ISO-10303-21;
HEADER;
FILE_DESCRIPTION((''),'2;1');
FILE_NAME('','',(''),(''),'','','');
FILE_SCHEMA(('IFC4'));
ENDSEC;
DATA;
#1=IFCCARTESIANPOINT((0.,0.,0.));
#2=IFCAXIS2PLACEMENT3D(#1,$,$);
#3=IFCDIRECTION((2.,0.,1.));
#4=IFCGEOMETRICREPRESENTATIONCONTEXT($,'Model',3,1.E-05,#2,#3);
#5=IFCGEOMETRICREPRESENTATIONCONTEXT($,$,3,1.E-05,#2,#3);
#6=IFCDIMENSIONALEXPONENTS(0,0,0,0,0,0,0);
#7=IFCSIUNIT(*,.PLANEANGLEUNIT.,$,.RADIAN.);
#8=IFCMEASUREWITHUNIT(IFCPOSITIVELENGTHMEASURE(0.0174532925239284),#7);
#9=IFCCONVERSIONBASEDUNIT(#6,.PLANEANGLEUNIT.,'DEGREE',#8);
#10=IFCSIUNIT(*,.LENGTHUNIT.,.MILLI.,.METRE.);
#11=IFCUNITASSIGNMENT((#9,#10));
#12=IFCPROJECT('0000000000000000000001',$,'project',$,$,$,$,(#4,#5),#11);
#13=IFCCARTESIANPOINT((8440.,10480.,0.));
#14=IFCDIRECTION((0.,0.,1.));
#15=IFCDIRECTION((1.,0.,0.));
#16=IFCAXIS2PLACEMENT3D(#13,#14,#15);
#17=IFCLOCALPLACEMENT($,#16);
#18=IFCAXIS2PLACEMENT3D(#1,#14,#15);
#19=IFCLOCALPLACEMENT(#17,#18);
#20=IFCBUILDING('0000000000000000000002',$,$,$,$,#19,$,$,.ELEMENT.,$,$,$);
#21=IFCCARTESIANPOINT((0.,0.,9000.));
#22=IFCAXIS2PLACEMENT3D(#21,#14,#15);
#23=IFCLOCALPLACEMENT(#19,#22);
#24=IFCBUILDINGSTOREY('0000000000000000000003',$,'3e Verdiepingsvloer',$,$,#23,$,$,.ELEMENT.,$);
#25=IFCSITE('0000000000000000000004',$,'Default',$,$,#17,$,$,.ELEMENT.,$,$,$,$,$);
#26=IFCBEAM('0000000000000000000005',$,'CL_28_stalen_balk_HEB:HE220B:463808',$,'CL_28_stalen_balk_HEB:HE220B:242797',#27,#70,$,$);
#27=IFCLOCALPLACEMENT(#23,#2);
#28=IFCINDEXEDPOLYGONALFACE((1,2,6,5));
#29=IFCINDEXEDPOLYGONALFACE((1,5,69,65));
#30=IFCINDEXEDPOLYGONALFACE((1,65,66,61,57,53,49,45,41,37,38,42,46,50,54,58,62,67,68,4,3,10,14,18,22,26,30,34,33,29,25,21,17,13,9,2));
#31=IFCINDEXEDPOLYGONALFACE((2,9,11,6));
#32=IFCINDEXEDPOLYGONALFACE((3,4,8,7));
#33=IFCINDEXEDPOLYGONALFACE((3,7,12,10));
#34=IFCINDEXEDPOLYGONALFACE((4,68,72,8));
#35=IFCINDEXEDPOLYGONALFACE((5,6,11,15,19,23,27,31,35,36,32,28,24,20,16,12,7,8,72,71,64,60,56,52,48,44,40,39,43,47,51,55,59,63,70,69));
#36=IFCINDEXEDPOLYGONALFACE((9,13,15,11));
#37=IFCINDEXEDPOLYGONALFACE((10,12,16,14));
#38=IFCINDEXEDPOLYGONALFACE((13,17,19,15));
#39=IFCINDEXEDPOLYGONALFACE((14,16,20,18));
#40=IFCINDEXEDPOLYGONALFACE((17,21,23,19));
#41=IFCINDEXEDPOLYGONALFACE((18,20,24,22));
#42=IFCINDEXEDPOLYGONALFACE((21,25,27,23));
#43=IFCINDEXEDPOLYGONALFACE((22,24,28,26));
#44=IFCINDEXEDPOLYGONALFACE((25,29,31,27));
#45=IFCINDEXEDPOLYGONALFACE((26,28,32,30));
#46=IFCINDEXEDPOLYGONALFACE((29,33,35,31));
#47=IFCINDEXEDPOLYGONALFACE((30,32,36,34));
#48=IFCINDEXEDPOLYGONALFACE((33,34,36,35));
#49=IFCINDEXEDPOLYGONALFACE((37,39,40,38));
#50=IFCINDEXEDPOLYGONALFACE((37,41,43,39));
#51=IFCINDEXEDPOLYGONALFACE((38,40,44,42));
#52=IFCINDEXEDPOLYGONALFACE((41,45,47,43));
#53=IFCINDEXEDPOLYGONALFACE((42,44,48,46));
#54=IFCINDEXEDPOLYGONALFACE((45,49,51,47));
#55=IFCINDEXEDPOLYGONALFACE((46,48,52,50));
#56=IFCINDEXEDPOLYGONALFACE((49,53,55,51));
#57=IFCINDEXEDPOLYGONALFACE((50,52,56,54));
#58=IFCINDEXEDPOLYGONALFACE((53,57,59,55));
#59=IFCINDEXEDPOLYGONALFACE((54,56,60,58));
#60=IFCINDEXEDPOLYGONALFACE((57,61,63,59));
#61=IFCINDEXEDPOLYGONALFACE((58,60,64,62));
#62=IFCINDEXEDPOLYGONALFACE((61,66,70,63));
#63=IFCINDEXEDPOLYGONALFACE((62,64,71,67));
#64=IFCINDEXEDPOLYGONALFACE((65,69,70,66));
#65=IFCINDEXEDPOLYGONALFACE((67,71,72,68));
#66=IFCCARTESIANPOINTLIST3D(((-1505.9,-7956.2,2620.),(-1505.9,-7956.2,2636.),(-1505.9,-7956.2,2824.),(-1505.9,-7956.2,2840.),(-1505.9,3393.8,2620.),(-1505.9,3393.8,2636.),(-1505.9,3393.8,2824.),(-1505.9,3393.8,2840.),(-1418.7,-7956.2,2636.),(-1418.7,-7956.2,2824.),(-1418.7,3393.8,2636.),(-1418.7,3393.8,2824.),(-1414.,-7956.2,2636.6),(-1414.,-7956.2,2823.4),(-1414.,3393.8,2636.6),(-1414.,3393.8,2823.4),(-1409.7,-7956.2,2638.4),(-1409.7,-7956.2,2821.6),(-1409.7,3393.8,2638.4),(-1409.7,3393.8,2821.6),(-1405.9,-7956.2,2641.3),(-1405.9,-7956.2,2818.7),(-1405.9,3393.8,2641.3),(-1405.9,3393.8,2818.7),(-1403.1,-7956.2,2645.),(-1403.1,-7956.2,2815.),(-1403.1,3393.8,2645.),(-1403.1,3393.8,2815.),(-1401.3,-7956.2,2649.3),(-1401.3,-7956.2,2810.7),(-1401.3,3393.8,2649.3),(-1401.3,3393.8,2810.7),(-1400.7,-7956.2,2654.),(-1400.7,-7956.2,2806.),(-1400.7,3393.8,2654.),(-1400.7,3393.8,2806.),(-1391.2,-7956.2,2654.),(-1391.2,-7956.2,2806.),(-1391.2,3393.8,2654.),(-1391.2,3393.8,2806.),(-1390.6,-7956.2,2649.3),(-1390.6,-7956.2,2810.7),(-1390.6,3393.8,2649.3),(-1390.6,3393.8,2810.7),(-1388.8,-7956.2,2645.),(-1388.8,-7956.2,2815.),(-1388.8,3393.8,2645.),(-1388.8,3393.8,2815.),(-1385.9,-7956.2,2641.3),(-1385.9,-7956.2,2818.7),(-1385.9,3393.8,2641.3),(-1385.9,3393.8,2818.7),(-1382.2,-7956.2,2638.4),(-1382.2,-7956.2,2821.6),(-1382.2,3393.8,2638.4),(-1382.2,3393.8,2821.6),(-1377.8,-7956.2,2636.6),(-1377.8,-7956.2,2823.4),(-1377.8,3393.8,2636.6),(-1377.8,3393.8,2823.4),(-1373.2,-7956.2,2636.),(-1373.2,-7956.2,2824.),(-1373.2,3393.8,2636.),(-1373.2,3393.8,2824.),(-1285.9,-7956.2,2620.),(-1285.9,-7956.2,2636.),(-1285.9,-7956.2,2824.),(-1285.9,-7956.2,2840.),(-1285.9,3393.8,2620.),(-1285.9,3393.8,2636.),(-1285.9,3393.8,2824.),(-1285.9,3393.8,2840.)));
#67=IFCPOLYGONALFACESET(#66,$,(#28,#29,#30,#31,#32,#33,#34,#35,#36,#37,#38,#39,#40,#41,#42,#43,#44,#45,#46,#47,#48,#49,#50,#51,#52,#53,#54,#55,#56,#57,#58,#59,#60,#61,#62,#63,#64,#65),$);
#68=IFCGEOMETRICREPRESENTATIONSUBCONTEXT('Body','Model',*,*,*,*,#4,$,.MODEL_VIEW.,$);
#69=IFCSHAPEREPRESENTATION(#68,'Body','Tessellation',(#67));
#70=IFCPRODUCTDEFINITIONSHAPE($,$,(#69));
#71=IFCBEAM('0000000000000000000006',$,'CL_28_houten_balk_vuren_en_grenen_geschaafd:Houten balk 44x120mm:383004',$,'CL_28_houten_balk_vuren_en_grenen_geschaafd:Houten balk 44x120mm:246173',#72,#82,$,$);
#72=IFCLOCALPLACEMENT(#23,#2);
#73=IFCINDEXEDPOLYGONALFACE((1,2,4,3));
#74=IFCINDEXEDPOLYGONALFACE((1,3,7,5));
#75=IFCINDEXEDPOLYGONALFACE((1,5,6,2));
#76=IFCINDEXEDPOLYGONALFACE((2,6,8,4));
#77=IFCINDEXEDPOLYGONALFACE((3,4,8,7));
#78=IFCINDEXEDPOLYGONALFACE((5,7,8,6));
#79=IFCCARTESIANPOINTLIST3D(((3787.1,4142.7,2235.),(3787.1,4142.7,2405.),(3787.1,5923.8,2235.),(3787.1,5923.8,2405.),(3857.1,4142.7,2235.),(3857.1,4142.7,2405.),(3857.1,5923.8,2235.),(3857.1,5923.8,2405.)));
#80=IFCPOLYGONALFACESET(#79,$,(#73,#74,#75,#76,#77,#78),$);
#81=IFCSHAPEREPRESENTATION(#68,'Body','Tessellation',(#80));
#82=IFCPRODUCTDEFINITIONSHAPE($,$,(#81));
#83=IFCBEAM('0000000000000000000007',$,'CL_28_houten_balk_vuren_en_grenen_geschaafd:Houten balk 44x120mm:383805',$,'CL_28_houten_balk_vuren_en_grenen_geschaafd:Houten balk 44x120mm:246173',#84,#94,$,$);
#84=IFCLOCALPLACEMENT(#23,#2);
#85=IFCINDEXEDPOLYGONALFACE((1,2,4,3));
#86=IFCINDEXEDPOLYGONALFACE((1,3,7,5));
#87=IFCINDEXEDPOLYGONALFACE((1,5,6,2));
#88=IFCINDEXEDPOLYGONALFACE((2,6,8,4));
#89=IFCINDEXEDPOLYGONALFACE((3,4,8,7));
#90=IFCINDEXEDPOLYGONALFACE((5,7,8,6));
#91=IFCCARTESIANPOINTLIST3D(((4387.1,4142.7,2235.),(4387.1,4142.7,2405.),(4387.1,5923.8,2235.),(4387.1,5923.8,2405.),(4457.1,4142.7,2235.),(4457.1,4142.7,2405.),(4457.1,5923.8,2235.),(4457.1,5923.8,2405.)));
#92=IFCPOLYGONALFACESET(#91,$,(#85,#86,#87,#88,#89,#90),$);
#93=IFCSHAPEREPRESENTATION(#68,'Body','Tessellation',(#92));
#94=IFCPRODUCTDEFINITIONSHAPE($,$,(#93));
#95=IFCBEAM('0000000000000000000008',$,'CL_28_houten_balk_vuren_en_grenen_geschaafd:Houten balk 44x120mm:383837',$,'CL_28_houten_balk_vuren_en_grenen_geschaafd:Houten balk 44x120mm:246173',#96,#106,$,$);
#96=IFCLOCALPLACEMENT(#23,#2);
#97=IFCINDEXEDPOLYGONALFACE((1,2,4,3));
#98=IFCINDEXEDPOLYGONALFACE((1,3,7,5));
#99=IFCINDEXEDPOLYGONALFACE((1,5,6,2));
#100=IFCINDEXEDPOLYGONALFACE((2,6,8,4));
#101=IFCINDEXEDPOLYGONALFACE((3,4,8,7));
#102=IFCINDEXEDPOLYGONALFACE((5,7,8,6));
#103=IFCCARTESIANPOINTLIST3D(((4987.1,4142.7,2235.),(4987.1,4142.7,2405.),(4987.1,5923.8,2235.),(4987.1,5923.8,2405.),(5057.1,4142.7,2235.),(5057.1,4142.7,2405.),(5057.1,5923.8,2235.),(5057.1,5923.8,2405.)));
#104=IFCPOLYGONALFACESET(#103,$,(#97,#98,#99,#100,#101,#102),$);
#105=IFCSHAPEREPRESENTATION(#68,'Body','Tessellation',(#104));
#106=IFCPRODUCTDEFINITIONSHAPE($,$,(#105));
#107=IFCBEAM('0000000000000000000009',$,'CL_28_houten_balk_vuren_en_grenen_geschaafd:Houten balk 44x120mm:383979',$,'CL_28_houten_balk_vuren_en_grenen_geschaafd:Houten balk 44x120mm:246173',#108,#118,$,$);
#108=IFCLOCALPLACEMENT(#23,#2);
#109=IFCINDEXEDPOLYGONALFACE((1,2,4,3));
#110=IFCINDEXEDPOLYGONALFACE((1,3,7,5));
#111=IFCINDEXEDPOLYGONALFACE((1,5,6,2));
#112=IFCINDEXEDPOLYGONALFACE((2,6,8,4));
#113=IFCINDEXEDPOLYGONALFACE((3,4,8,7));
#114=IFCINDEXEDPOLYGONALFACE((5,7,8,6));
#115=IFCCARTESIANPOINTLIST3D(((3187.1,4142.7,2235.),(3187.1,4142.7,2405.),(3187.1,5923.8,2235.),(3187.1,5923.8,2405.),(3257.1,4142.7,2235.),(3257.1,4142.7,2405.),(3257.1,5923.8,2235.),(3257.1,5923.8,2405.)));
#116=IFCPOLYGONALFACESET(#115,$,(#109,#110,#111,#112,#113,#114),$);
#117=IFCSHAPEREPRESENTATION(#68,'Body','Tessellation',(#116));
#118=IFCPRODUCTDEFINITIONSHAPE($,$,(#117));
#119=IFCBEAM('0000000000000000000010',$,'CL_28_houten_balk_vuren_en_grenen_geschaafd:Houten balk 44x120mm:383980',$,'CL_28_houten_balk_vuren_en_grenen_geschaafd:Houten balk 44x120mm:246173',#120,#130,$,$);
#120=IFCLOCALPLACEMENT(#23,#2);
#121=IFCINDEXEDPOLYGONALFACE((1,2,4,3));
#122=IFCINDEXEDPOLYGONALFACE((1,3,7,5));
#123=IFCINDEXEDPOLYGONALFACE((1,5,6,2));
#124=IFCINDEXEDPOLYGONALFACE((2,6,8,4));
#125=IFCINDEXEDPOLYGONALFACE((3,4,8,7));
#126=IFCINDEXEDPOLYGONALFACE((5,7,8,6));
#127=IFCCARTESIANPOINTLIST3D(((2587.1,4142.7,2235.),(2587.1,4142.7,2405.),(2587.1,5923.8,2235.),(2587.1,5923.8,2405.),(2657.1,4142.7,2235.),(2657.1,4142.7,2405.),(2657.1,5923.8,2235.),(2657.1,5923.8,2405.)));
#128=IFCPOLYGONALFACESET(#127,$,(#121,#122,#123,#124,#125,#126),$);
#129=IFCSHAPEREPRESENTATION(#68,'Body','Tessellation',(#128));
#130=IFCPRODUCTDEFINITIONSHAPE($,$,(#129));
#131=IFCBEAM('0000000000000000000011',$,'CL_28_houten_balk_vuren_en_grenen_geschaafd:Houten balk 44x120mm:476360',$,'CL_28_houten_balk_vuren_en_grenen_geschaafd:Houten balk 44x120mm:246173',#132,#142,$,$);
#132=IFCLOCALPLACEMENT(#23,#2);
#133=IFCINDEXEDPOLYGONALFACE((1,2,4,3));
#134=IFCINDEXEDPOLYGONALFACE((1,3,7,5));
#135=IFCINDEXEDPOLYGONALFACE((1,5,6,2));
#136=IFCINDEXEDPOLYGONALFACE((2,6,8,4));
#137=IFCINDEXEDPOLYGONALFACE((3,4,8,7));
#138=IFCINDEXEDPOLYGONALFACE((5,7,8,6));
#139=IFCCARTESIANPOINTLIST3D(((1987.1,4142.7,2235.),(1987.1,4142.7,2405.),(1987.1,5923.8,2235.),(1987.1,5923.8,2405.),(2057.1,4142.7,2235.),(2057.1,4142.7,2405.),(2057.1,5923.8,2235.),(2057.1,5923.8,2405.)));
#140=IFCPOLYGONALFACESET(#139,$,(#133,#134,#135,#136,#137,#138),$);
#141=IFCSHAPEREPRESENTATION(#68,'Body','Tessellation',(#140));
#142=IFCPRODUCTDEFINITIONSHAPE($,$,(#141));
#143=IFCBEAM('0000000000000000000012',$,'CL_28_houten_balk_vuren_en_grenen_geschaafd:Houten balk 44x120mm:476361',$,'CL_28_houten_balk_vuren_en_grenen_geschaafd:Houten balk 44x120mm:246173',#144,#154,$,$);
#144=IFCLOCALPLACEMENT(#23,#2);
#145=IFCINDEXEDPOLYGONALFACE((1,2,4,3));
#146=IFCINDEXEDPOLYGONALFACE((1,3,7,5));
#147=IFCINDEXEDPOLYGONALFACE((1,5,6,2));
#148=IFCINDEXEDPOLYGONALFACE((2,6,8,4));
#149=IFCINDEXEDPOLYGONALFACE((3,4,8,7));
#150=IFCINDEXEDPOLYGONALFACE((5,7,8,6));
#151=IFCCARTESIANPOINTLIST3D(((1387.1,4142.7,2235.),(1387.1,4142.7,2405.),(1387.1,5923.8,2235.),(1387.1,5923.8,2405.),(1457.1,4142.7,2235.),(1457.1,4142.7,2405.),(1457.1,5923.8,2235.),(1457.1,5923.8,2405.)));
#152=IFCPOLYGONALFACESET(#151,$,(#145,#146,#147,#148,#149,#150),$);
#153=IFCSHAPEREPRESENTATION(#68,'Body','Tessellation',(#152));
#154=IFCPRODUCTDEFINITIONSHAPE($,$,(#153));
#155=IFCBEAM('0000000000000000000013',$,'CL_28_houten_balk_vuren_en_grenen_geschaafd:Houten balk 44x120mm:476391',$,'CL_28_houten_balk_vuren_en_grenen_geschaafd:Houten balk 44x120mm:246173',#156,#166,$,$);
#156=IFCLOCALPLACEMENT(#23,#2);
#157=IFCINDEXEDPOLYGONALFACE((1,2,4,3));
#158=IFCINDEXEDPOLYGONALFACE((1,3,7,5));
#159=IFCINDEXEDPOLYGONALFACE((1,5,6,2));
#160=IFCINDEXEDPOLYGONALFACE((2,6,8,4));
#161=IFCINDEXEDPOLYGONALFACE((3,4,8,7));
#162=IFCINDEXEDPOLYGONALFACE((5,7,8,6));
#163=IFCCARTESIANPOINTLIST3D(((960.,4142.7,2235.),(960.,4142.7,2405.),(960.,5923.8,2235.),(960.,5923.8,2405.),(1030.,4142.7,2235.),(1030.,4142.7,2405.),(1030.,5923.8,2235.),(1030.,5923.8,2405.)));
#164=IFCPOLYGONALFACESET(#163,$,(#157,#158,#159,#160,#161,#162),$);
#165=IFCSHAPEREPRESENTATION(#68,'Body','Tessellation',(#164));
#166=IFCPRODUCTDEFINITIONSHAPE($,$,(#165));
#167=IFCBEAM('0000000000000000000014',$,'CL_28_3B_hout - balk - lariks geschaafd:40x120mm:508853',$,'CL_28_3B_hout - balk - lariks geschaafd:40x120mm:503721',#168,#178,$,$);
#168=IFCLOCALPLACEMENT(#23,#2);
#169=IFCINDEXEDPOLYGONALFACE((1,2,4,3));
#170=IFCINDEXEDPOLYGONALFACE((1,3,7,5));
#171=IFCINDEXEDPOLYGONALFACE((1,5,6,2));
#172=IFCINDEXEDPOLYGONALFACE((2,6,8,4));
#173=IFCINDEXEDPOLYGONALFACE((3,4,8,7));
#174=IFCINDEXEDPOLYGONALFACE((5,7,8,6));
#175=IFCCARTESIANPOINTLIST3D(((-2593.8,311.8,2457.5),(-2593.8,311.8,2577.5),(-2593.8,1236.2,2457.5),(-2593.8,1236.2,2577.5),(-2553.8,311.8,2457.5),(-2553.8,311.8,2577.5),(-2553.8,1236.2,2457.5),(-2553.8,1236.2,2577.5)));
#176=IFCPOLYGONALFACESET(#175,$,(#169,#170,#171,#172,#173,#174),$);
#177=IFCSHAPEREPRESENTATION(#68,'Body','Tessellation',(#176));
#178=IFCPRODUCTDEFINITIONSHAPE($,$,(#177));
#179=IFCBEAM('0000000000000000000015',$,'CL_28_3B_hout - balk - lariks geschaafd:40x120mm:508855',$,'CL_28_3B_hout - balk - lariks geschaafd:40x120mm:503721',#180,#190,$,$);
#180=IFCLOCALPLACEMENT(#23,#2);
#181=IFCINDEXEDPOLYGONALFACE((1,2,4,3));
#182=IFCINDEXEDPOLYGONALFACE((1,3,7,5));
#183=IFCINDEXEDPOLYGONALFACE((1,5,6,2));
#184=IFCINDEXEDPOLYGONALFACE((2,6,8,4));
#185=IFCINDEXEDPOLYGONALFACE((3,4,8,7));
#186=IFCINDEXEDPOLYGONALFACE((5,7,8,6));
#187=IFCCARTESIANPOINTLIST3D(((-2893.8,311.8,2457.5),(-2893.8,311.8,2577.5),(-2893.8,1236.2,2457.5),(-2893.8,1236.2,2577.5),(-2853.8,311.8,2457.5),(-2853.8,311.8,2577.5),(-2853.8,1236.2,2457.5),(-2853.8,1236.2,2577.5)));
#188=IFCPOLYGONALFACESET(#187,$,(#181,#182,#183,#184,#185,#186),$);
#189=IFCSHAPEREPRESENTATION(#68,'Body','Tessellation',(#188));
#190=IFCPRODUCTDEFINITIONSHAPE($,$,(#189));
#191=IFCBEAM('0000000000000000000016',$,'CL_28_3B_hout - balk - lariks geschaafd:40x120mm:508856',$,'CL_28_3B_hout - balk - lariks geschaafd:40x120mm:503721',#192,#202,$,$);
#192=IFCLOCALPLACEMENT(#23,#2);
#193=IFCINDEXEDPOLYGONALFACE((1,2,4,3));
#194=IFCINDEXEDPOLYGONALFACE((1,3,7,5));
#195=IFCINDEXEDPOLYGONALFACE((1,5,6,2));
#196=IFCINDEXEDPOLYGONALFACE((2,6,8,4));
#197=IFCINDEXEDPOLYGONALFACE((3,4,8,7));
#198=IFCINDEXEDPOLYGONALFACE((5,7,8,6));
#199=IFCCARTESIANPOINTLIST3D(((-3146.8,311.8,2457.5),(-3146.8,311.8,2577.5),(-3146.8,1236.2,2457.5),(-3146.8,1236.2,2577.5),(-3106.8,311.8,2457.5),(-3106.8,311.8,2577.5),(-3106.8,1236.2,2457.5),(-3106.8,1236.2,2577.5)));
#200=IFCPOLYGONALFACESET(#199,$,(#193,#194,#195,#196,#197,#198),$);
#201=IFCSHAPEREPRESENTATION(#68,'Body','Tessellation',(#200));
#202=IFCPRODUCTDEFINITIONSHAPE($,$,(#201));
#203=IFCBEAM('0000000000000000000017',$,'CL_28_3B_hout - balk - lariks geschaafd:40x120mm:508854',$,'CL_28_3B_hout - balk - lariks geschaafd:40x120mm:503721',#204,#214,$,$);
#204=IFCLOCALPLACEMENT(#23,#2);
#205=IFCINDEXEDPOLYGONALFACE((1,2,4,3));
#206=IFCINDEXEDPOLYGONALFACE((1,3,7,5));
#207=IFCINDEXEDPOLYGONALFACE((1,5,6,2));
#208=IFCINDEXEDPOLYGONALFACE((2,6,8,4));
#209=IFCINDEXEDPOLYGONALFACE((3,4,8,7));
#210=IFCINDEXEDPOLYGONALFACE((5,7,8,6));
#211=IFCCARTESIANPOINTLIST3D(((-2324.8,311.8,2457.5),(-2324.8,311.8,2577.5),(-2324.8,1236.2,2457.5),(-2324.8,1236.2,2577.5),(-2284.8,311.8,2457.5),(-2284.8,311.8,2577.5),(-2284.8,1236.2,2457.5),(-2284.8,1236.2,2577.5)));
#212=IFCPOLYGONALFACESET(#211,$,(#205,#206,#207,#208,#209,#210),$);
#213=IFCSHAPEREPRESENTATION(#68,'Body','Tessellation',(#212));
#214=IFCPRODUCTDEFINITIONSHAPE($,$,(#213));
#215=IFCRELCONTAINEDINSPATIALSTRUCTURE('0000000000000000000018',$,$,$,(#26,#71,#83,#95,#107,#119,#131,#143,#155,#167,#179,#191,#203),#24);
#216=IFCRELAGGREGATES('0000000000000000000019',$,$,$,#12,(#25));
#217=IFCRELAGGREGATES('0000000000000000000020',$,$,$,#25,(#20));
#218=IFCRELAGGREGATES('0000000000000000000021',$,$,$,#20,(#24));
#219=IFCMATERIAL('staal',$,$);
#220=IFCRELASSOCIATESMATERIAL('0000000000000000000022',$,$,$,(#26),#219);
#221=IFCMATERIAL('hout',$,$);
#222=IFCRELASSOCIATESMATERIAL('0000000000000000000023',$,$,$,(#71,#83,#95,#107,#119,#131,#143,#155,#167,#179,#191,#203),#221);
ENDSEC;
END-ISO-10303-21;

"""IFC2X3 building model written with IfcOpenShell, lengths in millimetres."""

from ifc_helpers import new_model, entity, si_unit, converted_unit, direction, frame, frame_2d, origin, origin_with_axes, place, context, subcontext, project, spatial, rectangle, i_section, extrude, source, transform, mapped, material, element, save


model = new_model("IFC2X3")

# Units and contexts
model_context = context("Model", 3, precision=1e-05, world=origin(), true_north=direction((2.0, 0.0, 1.0)))
context_of_model = context(None, 3, precision=1e-05, world=origin(), true_north=direction((2.0, 0.0, 1.0)))
body_context = subcontext(model_context, "Body", "Model", "MODEL_VIEW")
ifc_project = project(units=[converted_unit("PLANEANGLEUNIT", "DEGREE", entity("IfcPositiveLengthMeasure", 0.0174532925239284), si_unit("PLANEANGLEUNIT", "RADIAN"), dimensions=[0, 0, 0, 0, 0, 0, 0]), si_unit("LENGTHUNIT", "METRE", prefix="MILLI")], contexts=[model_context, context_of_model])

# Site, building, storey
site_placement = place(None, frame((8440.0, 10480.0, 0.0), z_axis=(0.0, 0.0, 1.0), x_axis=(1.0, 0.0, 0.0)))
site = spatial("IfcSite", under=ifc_project, at=site_placement, Name="Default", CompositionType="ELEMENT")
building_placement = place(site_placement, origin_with_axes())
building = spatial("IfcBuilding", under=site, at=building_placement, CompositionType="ELEMENT")
storey_placement = place(building_placement, frame((0.0, 0.0, 9000.0), z_axis=(0.0, 0.0, 1.0), x_axis=(1.0, 0.0, 0.0)))
storey = spatial("IfcBuildingStorey", under=building, at=storey_placement, Name="3e Verdiepingsvloer", CompositionType="ELEMENT")

# Beams
ifc_material_1 = material(Name="staal")
shared_shape_1 = source(origin(), body_context, "Body", "SweptSolid", [
    extrude(i_section(OverallWidth=220.0, OverallDepth=220.0, WebThickness=9.5, FlangeThickness=16.0, FilletRadius=18.0, at=frame_2d((0.0, 0.0), x_axis=(0.0, 1.0))), frame((0.0, 0.0, -110.0), z_axis=(1.0, 0.0, 0.0), x_axis=(0.0, 0.0, -1.0)), (0.0, 0.0, 1.0), 11350.0),
])
beam_1_placement = place(storey_placement, frame((-1395.9, -7956.2, 2840.0), z_axis=(0.0, 0.0, 1.0), x_axis=(0.0, 1.0, 0.0)))
element("IfcBeam", 1, at=beam_1_placement, inside=storey, material=ifc_material_1, Name="CL_28_stalen_balk_HEB:HE220B:463808", ObjectType="CL_28_stalen_balk_HEB:HE220B:242797", context=body_context, shape_type="MappedRepresentation", body=[
    mapped(shared_shape_1, transform((0.0, 0.0, 0.0))),
])
ifc_material_2 = material(Name="hout")
shared_shape_2 = source(origin(), body_context, "Body", "SweptSolid", [
    extrude(rectangle(XDim=170.0, YDim=70.0, at=frame_2d((0.0, 0.0), x_axis=(1.0, 0.0))), frame((0.0, 0.0, -85.0), z_axis=(1.0, 0.0, 0.0), x_axis=(0.0, 0.0, -1.0)), (0.0, 0.0, 1.0), 1781.1),
])
for number, where, z_axis, x_axis, name in (
    (2, (3822.1, 4142.7, 2405.0), (0.0, 0.0, 1.0), (0.0, 1.0, 0.0), "CL_28_houten_balk_vuren_en_grenen_geschaafd:Houten balk 44x120mm:383004"),
    (3, (4422.1, 4142.7, 2405.0), (0.0, 0.0, 1.0), (0.0, 1.0, 0.0), "CL_28_houten_balk_vuren_en_grenen_geschaafd:Houten balk 44x120mm:383805"),
    (4, (5022.1, 4142.7, 2405.0), (0.0, 0.0, 1.0), (0.0, 1.0, 0.0), "CL_28_houten_balk_vuren_en_grenen_geschaafd:Houten balk 44x120mm:383837"),
    (5, (3222.1, 4142.7, 2405.0), (0.0, 0.0, 1.0), (0.0, 1.0, 0.0), "CL_28_houten_balk_vuren_en_grenen_geschaafd:Houten balk 44x120mm:383979"),
    (6, (2622.1, 4142.7, 2405.0), (0.0, 0.0, 1.0), (0.0, 1.0, 0.0), "CL_28_houten_balk_vuren_en_grenen_geschaafd:Houten balk 44x120mm:383980"),
    (7, (2022.1, 4142.7, 2405.0), (0.0, 0.0, 1.0), (0.0, 1.0, 0.0), "CL_28_houten_balk_vuren_en_grenen_geschaafd:Houten balk 44x120mm:476360"),
    (8, (1422.1, 4142.7, 2405.0), (0.0, 0.0, 1.0), (0.0, 1.0, 0.0), "CL_28_houten_balk_vuren_en_grenen_geschaafd:Houten balk 44x120mm:476361"),
    (9, (995.0, 4142.7, 2405.0), (0.0, 0.0, 1.0), (0.0, 1.0, 0.0), "CL_28_houten_balk_vuren_en_grenen_geschaafd:Houten balk 44x120mm:476391"),
):
    element("IfcBeam", number, at=place(storey_placement, frame(where, z_axis=z_axis, x_axis=x_axis)), inside=storey, material=ifc_material_2, Name=name, ObjectType="CL_28_houten_balk_vuren_en_grenen_geschaafd:Houten balk 44x120mm:246173", context=body_context, shape_type="MappedRepresentation", body=[
        mapped(shared_shape_2, transform((0.0, 0.0, 0.0))),
    ])
shared_shape_3 = source(origin(), body_context, "Body", "SweptSolid", [
    extrude(rectangle(XDim=120.0, YDim=40.0, at=frame_2d((0.0, 0.0), x_axis=(1.0, 0.0))), frame((68.6, 0.0, -60.0), z_axis=(1.0, 0.0, 0.0), x_axis=(0.0, 0.0, -1.0)), (0.0, 0.0, 1.0), 924.4),
])
for number, where, z_axis, x_axis, name in (
    (10, (-2573.8, 1304.8, 2577.5), (0.0, 0.0, 1.0), (0.0, -1.0, 0.0), "CL_28_3B_hout - balk - lariks geschaafd:40x120mm:508853"),
    (11, (-2873.8, 1304.8, 2577.5), (0.0, 0.0, 1.0), (0.0, -1.0, 0.0), "CL_28_3B_hout - balk - lariks geschaafd:40x120mm:508855"),
    (12, (-3126.8, 1304.8, 2577.5), (0.0, 0.0, 1.0), (0.0, -1.0, 0.0), "CL_28_3B_hout - balk - lariks geschaafd:40x120mm:508856"),
):
    element("IfcBeam", number, at=place(storey_placement, frame(where, z_axis=z_axis, x_axis=x_axis)), inside=storey, material=ifc_material_2, Name=name, ObjectType="CL_28_3B_hout - balk - lariks geschaafd:40x120mm:503721", context=body_context, shape_type="MappedRepresentation", body=[
        mapped(shared_shape_3, transform((0.0, 0.0, 0.0))),
    ])
beam_2_placement = place(storey_placement, frame((-2304.8, 1297.8, 2577.5), z_axis=(0.0, 0.0, 1.0), x_axis=(0.0, -1.0, 0.0)))
element("IfcBeam", 13, at=beam_2_placement, inside=storey, material=ifc_material_2, Name="CL_28_3B_hout - balk - lariks geschaafd:40x120mm:508854", ObjectType="CL_28_3B_hout - balk - lariks geschaafd:40x120mm:503721", context=body_context, shape_type="SweptSolid", body=[
    extrude(rectangle(XDim=120.0, YDim=40.0, at=frame_2d((0.0, 0.0), x_axis=(1.0, 0.0))), frame((61.6, 0.0, -60.0), z_axis=(1.0, 0.0, 0.0), x_axis=(0.0, 0.0, -1.0)), (0.0, 0.0, 1.0), 924.4),
])

save(model, "model.ifc")
